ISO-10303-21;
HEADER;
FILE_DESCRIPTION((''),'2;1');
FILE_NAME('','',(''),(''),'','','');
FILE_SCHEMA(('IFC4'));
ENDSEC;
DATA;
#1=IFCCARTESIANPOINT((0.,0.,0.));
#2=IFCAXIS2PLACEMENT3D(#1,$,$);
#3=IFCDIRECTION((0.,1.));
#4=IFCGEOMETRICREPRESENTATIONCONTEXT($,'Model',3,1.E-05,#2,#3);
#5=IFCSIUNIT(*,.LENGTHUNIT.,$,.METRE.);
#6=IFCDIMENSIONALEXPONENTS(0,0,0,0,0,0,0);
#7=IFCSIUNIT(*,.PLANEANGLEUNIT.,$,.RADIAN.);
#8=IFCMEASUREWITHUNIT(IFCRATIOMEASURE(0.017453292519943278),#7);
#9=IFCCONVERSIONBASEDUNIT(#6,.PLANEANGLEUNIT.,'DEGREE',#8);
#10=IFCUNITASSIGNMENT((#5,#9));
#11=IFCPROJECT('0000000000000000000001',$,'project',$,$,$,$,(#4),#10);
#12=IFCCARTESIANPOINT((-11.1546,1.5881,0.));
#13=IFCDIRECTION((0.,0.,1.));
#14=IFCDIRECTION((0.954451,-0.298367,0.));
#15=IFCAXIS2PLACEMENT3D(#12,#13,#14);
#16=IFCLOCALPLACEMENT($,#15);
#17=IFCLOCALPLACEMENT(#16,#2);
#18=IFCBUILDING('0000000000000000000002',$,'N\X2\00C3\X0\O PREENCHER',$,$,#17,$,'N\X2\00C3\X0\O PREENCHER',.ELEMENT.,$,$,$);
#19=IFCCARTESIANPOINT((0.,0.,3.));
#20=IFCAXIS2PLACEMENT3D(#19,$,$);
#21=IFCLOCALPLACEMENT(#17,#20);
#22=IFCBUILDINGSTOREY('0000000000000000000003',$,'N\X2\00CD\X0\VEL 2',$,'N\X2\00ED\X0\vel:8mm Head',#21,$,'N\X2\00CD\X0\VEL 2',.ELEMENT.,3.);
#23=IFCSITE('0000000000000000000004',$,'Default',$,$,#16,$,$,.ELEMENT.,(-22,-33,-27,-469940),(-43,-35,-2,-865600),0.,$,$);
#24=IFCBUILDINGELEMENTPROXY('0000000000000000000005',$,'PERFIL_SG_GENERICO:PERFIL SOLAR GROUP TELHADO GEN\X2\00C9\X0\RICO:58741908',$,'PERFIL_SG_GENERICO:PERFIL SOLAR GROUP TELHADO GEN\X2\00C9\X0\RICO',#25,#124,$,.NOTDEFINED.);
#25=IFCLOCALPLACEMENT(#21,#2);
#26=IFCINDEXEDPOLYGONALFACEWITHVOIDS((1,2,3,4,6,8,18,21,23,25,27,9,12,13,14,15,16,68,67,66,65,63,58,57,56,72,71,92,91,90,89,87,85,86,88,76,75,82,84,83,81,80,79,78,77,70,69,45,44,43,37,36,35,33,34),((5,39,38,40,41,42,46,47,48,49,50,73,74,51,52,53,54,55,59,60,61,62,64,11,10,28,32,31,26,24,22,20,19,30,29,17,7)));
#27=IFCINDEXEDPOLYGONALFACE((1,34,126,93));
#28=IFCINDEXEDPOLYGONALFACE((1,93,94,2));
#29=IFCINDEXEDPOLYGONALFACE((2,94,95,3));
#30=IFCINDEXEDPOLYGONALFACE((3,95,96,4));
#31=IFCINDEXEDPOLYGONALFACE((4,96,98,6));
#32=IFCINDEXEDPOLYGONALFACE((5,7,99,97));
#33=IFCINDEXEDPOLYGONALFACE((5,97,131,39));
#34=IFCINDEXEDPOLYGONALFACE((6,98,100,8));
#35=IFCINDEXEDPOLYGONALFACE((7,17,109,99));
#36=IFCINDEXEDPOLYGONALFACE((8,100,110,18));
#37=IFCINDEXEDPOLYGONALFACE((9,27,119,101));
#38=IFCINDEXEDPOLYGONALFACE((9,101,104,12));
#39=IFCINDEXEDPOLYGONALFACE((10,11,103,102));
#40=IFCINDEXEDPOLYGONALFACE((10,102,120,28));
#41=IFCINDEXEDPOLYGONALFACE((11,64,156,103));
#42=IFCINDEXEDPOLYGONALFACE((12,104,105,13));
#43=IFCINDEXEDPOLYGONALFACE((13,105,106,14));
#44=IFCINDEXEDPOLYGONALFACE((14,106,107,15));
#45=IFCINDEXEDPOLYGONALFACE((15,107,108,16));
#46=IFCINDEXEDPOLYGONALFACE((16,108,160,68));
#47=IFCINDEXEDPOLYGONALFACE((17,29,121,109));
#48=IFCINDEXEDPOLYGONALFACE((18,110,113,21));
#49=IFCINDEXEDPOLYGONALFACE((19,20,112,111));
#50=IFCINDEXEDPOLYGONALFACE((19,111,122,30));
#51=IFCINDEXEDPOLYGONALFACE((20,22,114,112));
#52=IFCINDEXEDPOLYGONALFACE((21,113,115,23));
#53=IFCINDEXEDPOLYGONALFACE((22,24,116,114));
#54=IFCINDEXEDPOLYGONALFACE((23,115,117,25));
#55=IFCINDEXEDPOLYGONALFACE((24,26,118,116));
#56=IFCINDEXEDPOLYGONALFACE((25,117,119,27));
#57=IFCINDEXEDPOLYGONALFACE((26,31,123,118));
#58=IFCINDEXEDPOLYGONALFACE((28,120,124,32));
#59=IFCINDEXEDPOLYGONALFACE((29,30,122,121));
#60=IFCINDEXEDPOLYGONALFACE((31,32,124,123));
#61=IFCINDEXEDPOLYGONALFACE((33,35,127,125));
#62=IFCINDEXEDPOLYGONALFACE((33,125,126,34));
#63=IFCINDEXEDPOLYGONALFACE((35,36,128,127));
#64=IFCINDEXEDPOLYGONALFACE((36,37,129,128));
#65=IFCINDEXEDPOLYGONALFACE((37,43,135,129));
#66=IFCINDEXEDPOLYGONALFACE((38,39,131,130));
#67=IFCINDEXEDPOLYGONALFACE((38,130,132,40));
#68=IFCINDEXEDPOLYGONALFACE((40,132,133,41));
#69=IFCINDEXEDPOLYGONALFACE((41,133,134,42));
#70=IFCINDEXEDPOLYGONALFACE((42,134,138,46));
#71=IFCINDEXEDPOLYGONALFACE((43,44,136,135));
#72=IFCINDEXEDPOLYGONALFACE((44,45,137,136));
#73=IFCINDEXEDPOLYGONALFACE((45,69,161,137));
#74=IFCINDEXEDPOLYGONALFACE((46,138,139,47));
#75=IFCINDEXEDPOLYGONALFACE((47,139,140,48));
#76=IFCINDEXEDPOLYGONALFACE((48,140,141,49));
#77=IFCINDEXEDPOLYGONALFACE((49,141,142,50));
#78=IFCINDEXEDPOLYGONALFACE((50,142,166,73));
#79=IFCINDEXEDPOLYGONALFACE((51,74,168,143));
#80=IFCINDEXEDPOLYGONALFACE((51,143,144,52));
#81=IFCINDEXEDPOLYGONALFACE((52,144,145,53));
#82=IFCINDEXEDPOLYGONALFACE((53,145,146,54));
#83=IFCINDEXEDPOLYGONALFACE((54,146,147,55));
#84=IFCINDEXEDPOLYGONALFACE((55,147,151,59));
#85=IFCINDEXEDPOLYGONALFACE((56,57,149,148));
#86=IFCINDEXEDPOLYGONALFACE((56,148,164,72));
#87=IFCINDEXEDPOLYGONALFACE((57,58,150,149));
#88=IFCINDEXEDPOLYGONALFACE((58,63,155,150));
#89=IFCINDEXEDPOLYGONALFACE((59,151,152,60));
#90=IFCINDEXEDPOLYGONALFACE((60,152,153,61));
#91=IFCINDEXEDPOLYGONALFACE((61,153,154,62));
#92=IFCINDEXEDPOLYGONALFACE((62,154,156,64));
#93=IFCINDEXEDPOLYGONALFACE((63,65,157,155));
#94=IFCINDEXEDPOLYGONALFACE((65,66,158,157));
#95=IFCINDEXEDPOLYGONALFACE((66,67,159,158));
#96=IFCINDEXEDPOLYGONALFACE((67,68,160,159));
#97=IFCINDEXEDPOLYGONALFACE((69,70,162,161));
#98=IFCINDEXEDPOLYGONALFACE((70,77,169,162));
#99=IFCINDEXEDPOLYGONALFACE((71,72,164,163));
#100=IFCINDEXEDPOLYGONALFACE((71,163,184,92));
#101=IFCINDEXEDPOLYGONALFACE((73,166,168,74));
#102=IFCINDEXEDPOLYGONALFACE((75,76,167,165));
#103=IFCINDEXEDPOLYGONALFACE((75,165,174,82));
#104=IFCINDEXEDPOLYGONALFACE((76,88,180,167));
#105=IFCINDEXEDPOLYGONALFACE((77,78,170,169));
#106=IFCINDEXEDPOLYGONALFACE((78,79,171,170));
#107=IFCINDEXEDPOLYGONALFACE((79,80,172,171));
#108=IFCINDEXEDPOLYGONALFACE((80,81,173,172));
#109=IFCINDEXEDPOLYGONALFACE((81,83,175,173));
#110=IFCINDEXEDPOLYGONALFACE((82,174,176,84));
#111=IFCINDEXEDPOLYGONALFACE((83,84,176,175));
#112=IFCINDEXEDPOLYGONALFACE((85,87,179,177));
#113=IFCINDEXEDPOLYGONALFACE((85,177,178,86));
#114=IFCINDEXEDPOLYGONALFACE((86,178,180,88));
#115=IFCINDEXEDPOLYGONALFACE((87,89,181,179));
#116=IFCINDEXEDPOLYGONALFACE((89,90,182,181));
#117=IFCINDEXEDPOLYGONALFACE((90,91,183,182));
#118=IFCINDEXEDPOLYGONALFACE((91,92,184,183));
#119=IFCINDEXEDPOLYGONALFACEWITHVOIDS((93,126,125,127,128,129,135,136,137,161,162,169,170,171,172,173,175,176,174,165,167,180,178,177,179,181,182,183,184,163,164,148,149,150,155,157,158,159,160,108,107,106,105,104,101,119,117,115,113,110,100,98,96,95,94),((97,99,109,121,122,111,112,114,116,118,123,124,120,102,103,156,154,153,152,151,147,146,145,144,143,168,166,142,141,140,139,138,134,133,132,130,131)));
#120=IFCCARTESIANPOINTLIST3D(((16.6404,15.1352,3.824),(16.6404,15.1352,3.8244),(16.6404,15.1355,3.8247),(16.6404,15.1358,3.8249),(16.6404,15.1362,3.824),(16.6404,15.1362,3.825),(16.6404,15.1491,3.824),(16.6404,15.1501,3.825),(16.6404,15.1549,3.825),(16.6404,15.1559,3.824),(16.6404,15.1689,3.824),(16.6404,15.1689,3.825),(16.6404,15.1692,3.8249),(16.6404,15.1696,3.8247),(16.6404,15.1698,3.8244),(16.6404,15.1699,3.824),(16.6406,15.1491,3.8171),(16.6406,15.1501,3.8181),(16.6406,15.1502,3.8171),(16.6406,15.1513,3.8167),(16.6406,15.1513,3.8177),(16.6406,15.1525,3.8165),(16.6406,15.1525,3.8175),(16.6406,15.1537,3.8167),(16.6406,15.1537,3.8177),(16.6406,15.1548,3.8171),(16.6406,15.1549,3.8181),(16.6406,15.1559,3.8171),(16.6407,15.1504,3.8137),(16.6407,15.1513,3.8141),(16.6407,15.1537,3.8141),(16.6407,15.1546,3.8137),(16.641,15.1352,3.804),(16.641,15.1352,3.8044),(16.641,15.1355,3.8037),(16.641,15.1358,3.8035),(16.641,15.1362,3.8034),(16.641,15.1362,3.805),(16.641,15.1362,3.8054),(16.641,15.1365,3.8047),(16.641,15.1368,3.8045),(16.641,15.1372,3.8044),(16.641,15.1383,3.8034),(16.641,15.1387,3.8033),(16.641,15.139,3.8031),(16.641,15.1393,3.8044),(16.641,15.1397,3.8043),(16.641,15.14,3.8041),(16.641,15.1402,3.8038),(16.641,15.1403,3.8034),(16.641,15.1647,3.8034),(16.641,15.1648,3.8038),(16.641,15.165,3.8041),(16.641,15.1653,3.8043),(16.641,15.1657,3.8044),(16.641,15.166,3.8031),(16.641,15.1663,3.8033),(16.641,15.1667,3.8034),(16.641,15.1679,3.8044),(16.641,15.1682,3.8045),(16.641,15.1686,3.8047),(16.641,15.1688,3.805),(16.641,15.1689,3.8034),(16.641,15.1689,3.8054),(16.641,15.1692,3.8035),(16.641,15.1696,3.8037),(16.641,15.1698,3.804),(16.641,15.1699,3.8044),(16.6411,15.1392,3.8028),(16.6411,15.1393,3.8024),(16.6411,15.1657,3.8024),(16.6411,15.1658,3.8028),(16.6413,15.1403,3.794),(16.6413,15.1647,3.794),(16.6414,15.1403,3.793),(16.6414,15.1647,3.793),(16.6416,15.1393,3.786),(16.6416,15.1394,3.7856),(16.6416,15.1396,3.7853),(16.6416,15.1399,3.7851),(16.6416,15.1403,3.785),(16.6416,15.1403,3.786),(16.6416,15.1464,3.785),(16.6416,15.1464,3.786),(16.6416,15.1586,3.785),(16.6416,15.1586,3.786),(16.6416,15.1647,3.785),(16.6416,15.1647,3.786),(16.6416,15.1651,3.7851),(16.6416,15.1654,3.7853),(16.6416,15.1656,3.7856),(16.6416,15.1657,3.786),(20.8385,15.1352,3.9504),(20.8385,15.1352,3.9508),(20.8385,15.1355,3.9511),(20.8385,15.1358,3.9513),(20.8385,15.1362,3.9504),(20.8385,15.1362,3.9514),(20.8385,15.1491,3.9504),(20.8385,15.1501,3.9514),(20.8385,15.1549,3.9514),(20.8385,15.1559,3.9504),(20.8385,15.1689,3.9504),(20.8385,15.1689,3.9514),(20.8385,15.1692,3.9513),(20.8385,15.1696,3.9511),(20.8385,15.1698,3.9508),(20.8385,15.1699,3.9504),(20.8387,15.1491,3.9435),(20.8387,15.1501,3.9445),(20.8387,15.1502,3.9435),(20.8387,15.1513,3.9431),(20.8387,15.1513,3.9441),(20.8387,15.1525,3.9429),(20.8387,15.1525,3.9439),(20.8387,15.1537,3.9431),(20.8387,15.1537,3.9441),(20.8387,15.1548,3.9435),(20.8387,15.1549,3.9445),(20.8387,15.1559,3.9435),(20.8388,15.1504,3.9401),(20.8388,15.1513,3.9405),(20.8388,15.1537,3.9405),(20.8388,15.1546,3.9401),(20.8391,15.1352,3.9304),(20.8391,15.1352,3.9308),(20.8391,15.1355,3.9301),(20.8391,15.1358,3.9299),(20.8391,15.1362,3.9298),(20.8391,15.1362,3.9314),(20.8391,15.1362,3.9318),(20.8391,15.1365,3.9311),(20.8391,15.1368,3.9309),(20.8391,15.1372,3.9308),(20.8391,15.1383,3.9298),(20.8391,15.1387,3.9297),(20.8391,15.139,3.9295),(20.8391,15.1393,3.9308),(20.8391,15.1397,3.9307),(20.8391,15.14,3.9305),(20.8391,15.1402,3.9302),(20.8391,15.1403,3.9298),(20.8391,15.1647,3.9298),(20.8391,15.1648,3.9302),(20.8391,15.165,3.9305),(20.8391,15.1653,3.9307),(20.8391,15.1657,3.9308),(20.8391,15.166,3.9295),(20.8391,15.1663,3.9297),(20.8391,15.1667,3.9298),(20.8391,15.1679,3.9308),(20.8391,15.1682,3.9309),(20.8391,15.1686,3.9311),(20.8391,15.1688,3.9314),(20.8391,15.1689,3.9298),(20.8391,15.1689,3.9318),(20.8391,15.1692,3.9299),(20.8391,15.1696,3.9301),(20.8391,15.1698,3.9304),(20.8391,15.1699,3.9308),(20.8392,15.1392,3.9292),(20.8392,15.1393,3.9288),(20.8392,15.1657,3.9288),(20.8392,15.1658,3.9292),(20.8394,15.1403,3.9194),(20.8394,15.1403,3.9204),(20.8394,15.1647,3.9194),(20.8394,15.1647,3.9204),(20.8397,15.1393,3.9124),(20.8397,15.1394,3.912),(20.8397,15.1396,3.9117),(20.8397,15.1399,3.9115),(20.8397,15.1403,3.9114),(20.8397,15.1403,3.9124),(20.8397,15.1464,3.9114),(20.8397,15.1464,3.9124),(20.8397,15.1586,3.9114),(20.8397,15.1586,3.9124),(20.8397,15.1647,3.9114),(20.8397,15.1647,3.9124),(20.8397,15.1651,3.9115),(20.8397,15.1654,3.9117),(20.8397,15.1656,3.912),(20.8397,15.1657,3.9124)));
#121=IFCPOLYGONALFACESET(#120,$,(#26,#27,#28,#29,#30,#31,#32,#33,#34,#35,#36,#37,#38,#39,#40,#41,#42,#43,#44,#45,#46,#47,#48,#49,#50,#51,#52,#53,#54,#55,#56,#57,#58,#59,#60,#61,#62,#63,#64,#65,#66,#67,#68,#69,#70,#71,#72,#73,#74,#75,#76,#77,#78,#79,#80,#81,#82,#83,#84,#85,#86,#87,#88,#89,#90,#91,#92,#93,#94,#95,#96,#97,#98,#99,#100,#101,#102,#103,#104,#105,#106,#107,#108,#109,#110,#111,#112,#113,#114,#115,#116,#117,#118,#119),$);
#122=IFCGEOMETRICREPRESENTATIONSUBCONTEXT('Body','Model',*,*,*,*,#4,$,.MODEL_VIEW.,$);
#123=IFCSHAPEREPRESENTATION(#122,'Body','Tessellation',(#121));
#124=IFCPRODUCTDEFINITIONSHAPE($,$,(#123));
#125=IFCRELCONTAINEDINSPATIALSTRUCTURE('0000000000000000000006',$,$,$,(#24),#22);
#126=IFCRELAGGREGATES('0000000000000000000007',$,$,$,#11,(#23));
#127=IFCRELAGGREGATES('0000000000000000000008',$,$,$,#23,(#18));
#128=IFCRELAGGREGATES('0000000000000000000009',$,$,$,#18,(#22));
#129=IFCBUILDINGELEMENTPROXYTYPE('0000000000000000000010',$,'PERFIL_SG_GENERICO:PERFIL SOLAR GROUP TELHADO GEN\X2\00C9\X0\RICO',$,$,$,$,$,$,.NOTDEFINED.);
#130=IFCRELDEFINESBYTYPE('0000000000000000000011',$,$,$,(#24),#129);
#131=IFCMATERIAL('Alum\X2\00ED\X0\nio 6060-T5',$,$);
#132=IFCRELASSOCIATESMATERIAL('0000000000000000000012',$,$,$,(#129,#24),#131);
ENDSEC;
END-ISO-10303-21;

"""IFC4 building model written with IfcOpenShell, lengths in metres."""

from ifc_helpers import new_model, entity, si_unit, converted_unit, direction, frame, origin, place, context, subcontext, project, spatial, line, arc, indexed_curve, outline, extrude, source, transform, mapped, material, type_object, type_shapes, element, save


model = new_model("IFC4")

# Units and contexts
model_context = context("Model", 3, precision=1e-05, world=origin(), true_north=direction((0.0, 1.0)))
body_context = subcontext(model_context, "Body", "Model", "MODEL_VIEW")
ifc_project = project(units=[si_unit("LENGTHUNIT", "METRE"), converted_unit("PLANEANGLEUNIT", "DEGREE", entity("IfcRatioMeasure", 0.017453292519943278), si_unit("PLANEANGLEUNIT", "RADIAN"), dimensions=[0, 0, 0, 0, 0, 0, 0])], contexts=[model_context])

# Site, building, storey
site_placement = place(None, frame((-11.1546, 1.5881, 0.0), z_axis=(0.0, 0.0, 1.0), x_axis=(0.954451, -0.298367, 0.0)))
site = spatial("IfcSite", under=ifc_project, at=site_placement, Name="Default", CompositionType="ELEMENT", RefLatitude=(-22, -33, -27, -469940), RefLongitude=(-43, -35, -2, -865600), RefElevation=0.0)
building_placement = place(site_placement, origin())
building = spatial("IfcBuilding", under=site, at=building_placement, Name="NÃO PREENCHER", LongName="NÃO PREENCHER", CompositionType="ELEMENT")
storey_placement = place(building_placement, frame((0.0, 0.0, 3.0)))
storey = spatial("IfcBuildingStorey", under=building, at=storey_placement, Name="NÍVEL 2", ObjectType="Nível:8mm Head", LongName="NÍVEL 2", CompositionType="ELEMENT", Elevation=3.0)

# Building element proxy
ifc_material_1 = material(Name="Alumínio 6060-T5")
building_element_proxy_type_1 = type_object("IfcBuildingElementProxyType", Name="PERFIL_SG_GENERICO:PERFIL SOLAR GROUP TELHADO GENÉRICO", PredefinedType="NOTDEFINED", material=ifc_material_1)
shared_shape_1 = source(origin(), body_context, "Body", "SweptSolid", [
    extrude(outline(indexed_curve([(-0.0122, -0.0169), (-0.0061, -0.0169), (-0.0061, -0.0159), (-0.0122, -0.0159), (-0.0122, -0.0089), (0.0122, -0.0089), (0.0122, -0.0159), (0.0061, -0.0159), (0.0061, -0.0169), (0.0122, -0.0169), (0.0129, -0.0166), (0.0132, -0.0159), (0.0132, 0.0005), (0.0135, 0.0012), (0.0142, 0.0015), (0.0164, 0.0015), (0.0171, 0.0018), (0.0174, 0.0025), (0.0174, 0.0221), (0.0171, 0.0228), (0.0164, 0.0231), (0.0024, 0.0231), (0.0024, 0.0162), (0.0, 0.0156), (-0.0024, 0.0162), (-0.0024, 0.0231), (-0.0164, 0.0231), (-0.0171, 0.0228), (-0.0174, 0.0221), (-0.0174, 0.0025), (-0.0171, 0.0018), (-0.0164, 0.0015), (-0.0142, 0.0015), (-0.0135, 0.0012), (-0.0132, 0.0005), (-0.0132, -0.0159), (-0.0129, -0.0166)], segments=[line(1, 2, 3, 4, 5, 6, 7, 8, 9, 10), arc(10, 11, 12), line(12, 13), arc(13, 14, 15), line(15, 16), arc(16, 17, 18), line(18, 19), arc(19, 20, 21), line(21, 22, 23), arc(23, 24, 25), line(25, 26, 27), arc(27, 28, 29), line(29, 30), arc(30, 31, 32), line(32, 33), arc(33, 34, 35), line(35, 36), arc(36, 37, 1)], self_intersect=False), holes=[indexed_curve([(-0.0122, -0.0079), (-0.0122, 0.0015), (-0.0125, 0.0022), (-0.0132, 0.0025), (-0.0154, 0.0025), (-0.0161, 0.0028), (-0.0164, 0.0035), (-0.0164, 0.0221), (-0.0034, 0.0221), (-0.0034, 0.0152), (-0.0021, 0.0118), (-0.0012, 0.0122), (-0.0023, 0.0151), (0.0, 0.0146), (0.0023, 0.0151), (0.0012, 0.0122), (0.0021, 0.0118), (0.0034, 0.0152), (0.0034, 0.0221), (0.0164, 0.0221), (0.0164, 0.0035), (0.0161, 0.0028), (0.0154, 0.0025), (0.0132, 0.0025), (0.0125, 0.0022), (0.0122, 0.0015), (0.0122, -0.0079)], segments=[line(1, 2), arc(2, 3, 4), line(4, 5), arc(5, 6, 7), line(7, 8, 9, 10, 11, 12, 13), arc(13, 14, 15), line(15, 16, 17, 18, 19, 20, 21), arc(21, 22, 23), line(23, 24), arc(24, 25, 26), line(26, 27, 1)], self_intersect=False)]), frame((0.0, 0.0, 0.0169), z_axis=(1.0, 0.0, 0.0), x_axis=(0.0, 1.0, 0.0)), (0.0, 0.0, 1.0), 4.2),
])
type_shapes(building_element_proxy_type_1, [shared_shape_1])
for number, where, z_axis, x_axis, name in (
    (1, (16.6416, 15.1525, 3.785), (-0.030095, 0.0, 0.999547), (0.999547, 0.0, 0.030095), "PERFIL_SG_GENERICO:PERFIL SOLAR GROUP TELHADO GENÉRICO:58741908"),
):
    element("IfcBuildingElementProxy", number, at=place(storey_placement, frame(where, z_axis=z_axis, x_axis=x_axis)), inside=storey, type_object=building_element_proxy_type_1, material=ifc_material_1, Name=name, ObjectType="PERFIL_SG_GENERICO:PERFIL SOLAR GROUP TELHADO GENÉRICO", PredefinedType="NOTDEFINED", context=body_context, shape_type="MappedRepresentation", body=[
        mapped(shared_shape_1, transform((0.0, 0.0, 0.0), scale=1.0)),
    ])

save(model, "model.ifc")
